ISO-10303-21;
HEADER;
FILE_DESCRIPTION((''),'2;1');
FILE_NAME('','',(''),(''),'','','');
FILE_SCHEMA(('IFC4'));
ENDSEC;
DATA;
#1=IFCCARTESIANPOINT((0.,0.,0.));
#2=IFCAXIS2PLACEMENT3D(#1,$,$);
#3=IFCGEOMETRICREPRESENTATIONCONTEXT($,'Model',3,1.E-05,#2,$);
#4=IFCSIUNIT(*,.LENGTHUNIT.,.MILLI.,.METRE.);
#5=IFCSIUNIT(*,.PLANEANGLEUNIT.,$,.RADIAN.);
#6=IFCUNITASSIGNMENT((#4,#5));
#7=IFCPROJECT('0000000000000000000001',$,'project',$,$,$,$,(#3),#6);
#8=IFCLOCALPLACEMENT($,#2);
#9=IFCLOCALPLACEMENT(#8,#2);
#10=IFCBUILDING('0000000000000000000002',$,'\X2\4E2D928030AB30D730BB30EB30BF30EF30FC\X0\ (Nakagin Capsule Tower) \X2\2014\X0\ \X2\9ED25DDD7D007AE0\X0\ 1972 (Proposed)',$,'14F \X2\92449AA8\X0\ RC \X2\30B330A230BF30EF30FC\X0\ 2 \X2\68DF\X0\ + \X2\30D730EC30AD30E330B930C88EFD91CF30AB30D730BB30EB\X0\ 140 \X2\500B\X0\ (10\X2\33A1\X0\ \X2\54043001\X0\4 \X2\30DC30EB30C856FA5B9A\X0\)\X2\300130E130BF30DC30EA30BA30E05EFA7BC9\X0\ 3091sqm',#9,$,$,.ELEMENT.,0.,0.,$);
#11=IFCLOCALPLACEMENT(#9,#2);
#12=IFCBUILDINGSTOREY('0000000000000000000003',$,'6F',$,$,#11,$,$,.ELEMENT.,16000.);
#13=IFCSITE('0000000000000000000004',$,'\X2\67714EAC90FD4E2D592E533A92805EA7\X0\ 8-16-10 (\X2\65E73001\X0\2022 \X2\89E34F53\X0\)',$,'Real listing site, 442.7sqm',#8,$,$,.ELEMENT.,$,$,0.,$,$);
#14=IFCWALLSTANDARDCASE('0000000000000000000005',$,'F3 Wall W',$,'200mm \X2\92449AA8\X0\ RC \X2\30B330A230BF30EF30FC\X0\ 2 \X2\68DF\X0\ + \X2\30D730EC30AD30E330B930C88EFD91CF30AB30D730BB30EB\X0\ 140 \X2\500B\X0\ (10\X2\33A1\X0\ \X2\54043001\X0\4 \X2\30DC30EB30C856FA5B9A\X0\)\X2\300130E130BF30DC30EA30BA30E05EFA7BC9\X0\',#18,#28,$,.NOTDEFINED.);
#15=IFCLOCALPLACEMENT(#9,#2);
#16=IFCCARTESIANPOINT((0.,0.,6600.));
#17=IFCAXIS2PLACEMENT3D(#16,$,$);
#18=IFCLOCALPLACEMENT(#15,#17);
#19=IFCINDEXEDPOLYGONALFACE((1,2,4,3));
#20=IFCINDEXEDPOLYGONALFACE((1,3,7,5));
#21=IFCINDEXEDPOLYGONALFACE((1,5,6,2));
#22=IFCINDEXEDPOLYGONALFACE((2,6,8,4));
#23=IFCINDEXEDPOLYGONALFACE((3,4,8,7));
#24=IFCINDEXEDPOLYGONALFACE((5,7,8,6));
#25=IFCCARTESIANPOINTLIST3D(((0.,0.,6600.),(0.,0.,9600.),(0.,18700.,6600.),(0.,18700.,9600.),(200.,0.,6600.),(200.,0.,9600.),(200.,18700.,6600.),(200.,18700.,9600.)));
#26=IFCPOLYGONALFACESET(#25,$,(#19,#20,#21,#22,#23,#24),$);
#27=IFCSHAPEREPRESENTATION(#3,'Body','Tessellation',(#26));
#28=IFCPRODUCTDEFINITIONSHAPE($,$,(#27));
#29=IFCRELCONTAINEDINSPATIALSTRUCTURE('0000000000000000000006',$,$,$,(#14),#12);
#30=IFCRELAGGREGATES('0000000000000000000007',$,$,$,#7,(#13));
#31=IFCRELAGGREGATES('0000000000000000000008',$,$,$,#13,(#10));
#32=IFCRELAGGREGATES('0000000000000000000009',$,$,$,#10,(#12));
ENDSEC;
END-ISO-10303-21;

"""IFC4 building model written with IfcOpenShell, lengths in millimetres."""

from ifc_helpers import new_model, si_unit, frame, frame_2d, origin, place, context, project, spatial, rectangle, extrude, element, save


model = new_model("IFC4")

# Units and contexts
model_context = context("Model", 3, precision=1e-05, world=origin())
ifc_project = project(units=[si_unit("LENGTHUNIT", "METRE", prefix="MILLI"), si_unit("PLANEANGLEUNIT", "RADIAN")], contexts=[model_context])

# Site, building, storey
site_placement = place(None, origin())
site = spatial("IfcSite", under=ifc_project, at=site_placement, Name="東京都中央区銀座 8-16-10 (旧、2022 解体)", ObjectType="Real listing site, 442.7sqm", CompositionType="ELEMENT", RefElevation=0.0)
building_placement = place(site_placement, origin())
building = spatial("IfcBuilding", under=site, at=building_placement, Name="中銀カプセルタワー (Nakagin Capsule Tower) — 黒川紀章 1972 (Proposed)", ObjectType="14F 鉄骨 RC コアタワー 2 棟 + プレキャスト軽量カプセル 140 個 (10㎡ 各、4 ボルト固定)、メタボリズム建築 3091sqm", CompositionType="ELEMENT", ElevationOfRefHeight=0.0, ElevationOfTerrain=0.0)
storey_placement = place(building_placement, origin())
storey = spatial("IfcBuildingStorey", under=building, at=storey_placement, Name="6F", CompositionType="ELEMENT", Elevation=16000.0)

# Wall
placement = place(building_placement, origin())
wall_placement = place(placement, frame((0.0, 0.0, 6600.0)))
element("IfcWallStandardCase", 1, at=wall_placement, inside=storey, Name="F3 Wall W", ObjectType="200mm 鉄骨 RC コアタワー 2 棟 + プレキャスト軽量カプセル 140 個 (10㎡ 各、4 ボルト固定)、メタボリズム建築", PredefinedType="NOTDEFINED", context=model_context, shape_type="SweptSolid", body=[
    extrude(rectangle(XDim=200.0, YDim=18700.0, at=frame_2d((100.0, 9350.0))), frame((0.0, 0.0, 6600.0)), (0.0, 0.0, 1.0), 3000.0),
])

save(model, "model.ifc")
